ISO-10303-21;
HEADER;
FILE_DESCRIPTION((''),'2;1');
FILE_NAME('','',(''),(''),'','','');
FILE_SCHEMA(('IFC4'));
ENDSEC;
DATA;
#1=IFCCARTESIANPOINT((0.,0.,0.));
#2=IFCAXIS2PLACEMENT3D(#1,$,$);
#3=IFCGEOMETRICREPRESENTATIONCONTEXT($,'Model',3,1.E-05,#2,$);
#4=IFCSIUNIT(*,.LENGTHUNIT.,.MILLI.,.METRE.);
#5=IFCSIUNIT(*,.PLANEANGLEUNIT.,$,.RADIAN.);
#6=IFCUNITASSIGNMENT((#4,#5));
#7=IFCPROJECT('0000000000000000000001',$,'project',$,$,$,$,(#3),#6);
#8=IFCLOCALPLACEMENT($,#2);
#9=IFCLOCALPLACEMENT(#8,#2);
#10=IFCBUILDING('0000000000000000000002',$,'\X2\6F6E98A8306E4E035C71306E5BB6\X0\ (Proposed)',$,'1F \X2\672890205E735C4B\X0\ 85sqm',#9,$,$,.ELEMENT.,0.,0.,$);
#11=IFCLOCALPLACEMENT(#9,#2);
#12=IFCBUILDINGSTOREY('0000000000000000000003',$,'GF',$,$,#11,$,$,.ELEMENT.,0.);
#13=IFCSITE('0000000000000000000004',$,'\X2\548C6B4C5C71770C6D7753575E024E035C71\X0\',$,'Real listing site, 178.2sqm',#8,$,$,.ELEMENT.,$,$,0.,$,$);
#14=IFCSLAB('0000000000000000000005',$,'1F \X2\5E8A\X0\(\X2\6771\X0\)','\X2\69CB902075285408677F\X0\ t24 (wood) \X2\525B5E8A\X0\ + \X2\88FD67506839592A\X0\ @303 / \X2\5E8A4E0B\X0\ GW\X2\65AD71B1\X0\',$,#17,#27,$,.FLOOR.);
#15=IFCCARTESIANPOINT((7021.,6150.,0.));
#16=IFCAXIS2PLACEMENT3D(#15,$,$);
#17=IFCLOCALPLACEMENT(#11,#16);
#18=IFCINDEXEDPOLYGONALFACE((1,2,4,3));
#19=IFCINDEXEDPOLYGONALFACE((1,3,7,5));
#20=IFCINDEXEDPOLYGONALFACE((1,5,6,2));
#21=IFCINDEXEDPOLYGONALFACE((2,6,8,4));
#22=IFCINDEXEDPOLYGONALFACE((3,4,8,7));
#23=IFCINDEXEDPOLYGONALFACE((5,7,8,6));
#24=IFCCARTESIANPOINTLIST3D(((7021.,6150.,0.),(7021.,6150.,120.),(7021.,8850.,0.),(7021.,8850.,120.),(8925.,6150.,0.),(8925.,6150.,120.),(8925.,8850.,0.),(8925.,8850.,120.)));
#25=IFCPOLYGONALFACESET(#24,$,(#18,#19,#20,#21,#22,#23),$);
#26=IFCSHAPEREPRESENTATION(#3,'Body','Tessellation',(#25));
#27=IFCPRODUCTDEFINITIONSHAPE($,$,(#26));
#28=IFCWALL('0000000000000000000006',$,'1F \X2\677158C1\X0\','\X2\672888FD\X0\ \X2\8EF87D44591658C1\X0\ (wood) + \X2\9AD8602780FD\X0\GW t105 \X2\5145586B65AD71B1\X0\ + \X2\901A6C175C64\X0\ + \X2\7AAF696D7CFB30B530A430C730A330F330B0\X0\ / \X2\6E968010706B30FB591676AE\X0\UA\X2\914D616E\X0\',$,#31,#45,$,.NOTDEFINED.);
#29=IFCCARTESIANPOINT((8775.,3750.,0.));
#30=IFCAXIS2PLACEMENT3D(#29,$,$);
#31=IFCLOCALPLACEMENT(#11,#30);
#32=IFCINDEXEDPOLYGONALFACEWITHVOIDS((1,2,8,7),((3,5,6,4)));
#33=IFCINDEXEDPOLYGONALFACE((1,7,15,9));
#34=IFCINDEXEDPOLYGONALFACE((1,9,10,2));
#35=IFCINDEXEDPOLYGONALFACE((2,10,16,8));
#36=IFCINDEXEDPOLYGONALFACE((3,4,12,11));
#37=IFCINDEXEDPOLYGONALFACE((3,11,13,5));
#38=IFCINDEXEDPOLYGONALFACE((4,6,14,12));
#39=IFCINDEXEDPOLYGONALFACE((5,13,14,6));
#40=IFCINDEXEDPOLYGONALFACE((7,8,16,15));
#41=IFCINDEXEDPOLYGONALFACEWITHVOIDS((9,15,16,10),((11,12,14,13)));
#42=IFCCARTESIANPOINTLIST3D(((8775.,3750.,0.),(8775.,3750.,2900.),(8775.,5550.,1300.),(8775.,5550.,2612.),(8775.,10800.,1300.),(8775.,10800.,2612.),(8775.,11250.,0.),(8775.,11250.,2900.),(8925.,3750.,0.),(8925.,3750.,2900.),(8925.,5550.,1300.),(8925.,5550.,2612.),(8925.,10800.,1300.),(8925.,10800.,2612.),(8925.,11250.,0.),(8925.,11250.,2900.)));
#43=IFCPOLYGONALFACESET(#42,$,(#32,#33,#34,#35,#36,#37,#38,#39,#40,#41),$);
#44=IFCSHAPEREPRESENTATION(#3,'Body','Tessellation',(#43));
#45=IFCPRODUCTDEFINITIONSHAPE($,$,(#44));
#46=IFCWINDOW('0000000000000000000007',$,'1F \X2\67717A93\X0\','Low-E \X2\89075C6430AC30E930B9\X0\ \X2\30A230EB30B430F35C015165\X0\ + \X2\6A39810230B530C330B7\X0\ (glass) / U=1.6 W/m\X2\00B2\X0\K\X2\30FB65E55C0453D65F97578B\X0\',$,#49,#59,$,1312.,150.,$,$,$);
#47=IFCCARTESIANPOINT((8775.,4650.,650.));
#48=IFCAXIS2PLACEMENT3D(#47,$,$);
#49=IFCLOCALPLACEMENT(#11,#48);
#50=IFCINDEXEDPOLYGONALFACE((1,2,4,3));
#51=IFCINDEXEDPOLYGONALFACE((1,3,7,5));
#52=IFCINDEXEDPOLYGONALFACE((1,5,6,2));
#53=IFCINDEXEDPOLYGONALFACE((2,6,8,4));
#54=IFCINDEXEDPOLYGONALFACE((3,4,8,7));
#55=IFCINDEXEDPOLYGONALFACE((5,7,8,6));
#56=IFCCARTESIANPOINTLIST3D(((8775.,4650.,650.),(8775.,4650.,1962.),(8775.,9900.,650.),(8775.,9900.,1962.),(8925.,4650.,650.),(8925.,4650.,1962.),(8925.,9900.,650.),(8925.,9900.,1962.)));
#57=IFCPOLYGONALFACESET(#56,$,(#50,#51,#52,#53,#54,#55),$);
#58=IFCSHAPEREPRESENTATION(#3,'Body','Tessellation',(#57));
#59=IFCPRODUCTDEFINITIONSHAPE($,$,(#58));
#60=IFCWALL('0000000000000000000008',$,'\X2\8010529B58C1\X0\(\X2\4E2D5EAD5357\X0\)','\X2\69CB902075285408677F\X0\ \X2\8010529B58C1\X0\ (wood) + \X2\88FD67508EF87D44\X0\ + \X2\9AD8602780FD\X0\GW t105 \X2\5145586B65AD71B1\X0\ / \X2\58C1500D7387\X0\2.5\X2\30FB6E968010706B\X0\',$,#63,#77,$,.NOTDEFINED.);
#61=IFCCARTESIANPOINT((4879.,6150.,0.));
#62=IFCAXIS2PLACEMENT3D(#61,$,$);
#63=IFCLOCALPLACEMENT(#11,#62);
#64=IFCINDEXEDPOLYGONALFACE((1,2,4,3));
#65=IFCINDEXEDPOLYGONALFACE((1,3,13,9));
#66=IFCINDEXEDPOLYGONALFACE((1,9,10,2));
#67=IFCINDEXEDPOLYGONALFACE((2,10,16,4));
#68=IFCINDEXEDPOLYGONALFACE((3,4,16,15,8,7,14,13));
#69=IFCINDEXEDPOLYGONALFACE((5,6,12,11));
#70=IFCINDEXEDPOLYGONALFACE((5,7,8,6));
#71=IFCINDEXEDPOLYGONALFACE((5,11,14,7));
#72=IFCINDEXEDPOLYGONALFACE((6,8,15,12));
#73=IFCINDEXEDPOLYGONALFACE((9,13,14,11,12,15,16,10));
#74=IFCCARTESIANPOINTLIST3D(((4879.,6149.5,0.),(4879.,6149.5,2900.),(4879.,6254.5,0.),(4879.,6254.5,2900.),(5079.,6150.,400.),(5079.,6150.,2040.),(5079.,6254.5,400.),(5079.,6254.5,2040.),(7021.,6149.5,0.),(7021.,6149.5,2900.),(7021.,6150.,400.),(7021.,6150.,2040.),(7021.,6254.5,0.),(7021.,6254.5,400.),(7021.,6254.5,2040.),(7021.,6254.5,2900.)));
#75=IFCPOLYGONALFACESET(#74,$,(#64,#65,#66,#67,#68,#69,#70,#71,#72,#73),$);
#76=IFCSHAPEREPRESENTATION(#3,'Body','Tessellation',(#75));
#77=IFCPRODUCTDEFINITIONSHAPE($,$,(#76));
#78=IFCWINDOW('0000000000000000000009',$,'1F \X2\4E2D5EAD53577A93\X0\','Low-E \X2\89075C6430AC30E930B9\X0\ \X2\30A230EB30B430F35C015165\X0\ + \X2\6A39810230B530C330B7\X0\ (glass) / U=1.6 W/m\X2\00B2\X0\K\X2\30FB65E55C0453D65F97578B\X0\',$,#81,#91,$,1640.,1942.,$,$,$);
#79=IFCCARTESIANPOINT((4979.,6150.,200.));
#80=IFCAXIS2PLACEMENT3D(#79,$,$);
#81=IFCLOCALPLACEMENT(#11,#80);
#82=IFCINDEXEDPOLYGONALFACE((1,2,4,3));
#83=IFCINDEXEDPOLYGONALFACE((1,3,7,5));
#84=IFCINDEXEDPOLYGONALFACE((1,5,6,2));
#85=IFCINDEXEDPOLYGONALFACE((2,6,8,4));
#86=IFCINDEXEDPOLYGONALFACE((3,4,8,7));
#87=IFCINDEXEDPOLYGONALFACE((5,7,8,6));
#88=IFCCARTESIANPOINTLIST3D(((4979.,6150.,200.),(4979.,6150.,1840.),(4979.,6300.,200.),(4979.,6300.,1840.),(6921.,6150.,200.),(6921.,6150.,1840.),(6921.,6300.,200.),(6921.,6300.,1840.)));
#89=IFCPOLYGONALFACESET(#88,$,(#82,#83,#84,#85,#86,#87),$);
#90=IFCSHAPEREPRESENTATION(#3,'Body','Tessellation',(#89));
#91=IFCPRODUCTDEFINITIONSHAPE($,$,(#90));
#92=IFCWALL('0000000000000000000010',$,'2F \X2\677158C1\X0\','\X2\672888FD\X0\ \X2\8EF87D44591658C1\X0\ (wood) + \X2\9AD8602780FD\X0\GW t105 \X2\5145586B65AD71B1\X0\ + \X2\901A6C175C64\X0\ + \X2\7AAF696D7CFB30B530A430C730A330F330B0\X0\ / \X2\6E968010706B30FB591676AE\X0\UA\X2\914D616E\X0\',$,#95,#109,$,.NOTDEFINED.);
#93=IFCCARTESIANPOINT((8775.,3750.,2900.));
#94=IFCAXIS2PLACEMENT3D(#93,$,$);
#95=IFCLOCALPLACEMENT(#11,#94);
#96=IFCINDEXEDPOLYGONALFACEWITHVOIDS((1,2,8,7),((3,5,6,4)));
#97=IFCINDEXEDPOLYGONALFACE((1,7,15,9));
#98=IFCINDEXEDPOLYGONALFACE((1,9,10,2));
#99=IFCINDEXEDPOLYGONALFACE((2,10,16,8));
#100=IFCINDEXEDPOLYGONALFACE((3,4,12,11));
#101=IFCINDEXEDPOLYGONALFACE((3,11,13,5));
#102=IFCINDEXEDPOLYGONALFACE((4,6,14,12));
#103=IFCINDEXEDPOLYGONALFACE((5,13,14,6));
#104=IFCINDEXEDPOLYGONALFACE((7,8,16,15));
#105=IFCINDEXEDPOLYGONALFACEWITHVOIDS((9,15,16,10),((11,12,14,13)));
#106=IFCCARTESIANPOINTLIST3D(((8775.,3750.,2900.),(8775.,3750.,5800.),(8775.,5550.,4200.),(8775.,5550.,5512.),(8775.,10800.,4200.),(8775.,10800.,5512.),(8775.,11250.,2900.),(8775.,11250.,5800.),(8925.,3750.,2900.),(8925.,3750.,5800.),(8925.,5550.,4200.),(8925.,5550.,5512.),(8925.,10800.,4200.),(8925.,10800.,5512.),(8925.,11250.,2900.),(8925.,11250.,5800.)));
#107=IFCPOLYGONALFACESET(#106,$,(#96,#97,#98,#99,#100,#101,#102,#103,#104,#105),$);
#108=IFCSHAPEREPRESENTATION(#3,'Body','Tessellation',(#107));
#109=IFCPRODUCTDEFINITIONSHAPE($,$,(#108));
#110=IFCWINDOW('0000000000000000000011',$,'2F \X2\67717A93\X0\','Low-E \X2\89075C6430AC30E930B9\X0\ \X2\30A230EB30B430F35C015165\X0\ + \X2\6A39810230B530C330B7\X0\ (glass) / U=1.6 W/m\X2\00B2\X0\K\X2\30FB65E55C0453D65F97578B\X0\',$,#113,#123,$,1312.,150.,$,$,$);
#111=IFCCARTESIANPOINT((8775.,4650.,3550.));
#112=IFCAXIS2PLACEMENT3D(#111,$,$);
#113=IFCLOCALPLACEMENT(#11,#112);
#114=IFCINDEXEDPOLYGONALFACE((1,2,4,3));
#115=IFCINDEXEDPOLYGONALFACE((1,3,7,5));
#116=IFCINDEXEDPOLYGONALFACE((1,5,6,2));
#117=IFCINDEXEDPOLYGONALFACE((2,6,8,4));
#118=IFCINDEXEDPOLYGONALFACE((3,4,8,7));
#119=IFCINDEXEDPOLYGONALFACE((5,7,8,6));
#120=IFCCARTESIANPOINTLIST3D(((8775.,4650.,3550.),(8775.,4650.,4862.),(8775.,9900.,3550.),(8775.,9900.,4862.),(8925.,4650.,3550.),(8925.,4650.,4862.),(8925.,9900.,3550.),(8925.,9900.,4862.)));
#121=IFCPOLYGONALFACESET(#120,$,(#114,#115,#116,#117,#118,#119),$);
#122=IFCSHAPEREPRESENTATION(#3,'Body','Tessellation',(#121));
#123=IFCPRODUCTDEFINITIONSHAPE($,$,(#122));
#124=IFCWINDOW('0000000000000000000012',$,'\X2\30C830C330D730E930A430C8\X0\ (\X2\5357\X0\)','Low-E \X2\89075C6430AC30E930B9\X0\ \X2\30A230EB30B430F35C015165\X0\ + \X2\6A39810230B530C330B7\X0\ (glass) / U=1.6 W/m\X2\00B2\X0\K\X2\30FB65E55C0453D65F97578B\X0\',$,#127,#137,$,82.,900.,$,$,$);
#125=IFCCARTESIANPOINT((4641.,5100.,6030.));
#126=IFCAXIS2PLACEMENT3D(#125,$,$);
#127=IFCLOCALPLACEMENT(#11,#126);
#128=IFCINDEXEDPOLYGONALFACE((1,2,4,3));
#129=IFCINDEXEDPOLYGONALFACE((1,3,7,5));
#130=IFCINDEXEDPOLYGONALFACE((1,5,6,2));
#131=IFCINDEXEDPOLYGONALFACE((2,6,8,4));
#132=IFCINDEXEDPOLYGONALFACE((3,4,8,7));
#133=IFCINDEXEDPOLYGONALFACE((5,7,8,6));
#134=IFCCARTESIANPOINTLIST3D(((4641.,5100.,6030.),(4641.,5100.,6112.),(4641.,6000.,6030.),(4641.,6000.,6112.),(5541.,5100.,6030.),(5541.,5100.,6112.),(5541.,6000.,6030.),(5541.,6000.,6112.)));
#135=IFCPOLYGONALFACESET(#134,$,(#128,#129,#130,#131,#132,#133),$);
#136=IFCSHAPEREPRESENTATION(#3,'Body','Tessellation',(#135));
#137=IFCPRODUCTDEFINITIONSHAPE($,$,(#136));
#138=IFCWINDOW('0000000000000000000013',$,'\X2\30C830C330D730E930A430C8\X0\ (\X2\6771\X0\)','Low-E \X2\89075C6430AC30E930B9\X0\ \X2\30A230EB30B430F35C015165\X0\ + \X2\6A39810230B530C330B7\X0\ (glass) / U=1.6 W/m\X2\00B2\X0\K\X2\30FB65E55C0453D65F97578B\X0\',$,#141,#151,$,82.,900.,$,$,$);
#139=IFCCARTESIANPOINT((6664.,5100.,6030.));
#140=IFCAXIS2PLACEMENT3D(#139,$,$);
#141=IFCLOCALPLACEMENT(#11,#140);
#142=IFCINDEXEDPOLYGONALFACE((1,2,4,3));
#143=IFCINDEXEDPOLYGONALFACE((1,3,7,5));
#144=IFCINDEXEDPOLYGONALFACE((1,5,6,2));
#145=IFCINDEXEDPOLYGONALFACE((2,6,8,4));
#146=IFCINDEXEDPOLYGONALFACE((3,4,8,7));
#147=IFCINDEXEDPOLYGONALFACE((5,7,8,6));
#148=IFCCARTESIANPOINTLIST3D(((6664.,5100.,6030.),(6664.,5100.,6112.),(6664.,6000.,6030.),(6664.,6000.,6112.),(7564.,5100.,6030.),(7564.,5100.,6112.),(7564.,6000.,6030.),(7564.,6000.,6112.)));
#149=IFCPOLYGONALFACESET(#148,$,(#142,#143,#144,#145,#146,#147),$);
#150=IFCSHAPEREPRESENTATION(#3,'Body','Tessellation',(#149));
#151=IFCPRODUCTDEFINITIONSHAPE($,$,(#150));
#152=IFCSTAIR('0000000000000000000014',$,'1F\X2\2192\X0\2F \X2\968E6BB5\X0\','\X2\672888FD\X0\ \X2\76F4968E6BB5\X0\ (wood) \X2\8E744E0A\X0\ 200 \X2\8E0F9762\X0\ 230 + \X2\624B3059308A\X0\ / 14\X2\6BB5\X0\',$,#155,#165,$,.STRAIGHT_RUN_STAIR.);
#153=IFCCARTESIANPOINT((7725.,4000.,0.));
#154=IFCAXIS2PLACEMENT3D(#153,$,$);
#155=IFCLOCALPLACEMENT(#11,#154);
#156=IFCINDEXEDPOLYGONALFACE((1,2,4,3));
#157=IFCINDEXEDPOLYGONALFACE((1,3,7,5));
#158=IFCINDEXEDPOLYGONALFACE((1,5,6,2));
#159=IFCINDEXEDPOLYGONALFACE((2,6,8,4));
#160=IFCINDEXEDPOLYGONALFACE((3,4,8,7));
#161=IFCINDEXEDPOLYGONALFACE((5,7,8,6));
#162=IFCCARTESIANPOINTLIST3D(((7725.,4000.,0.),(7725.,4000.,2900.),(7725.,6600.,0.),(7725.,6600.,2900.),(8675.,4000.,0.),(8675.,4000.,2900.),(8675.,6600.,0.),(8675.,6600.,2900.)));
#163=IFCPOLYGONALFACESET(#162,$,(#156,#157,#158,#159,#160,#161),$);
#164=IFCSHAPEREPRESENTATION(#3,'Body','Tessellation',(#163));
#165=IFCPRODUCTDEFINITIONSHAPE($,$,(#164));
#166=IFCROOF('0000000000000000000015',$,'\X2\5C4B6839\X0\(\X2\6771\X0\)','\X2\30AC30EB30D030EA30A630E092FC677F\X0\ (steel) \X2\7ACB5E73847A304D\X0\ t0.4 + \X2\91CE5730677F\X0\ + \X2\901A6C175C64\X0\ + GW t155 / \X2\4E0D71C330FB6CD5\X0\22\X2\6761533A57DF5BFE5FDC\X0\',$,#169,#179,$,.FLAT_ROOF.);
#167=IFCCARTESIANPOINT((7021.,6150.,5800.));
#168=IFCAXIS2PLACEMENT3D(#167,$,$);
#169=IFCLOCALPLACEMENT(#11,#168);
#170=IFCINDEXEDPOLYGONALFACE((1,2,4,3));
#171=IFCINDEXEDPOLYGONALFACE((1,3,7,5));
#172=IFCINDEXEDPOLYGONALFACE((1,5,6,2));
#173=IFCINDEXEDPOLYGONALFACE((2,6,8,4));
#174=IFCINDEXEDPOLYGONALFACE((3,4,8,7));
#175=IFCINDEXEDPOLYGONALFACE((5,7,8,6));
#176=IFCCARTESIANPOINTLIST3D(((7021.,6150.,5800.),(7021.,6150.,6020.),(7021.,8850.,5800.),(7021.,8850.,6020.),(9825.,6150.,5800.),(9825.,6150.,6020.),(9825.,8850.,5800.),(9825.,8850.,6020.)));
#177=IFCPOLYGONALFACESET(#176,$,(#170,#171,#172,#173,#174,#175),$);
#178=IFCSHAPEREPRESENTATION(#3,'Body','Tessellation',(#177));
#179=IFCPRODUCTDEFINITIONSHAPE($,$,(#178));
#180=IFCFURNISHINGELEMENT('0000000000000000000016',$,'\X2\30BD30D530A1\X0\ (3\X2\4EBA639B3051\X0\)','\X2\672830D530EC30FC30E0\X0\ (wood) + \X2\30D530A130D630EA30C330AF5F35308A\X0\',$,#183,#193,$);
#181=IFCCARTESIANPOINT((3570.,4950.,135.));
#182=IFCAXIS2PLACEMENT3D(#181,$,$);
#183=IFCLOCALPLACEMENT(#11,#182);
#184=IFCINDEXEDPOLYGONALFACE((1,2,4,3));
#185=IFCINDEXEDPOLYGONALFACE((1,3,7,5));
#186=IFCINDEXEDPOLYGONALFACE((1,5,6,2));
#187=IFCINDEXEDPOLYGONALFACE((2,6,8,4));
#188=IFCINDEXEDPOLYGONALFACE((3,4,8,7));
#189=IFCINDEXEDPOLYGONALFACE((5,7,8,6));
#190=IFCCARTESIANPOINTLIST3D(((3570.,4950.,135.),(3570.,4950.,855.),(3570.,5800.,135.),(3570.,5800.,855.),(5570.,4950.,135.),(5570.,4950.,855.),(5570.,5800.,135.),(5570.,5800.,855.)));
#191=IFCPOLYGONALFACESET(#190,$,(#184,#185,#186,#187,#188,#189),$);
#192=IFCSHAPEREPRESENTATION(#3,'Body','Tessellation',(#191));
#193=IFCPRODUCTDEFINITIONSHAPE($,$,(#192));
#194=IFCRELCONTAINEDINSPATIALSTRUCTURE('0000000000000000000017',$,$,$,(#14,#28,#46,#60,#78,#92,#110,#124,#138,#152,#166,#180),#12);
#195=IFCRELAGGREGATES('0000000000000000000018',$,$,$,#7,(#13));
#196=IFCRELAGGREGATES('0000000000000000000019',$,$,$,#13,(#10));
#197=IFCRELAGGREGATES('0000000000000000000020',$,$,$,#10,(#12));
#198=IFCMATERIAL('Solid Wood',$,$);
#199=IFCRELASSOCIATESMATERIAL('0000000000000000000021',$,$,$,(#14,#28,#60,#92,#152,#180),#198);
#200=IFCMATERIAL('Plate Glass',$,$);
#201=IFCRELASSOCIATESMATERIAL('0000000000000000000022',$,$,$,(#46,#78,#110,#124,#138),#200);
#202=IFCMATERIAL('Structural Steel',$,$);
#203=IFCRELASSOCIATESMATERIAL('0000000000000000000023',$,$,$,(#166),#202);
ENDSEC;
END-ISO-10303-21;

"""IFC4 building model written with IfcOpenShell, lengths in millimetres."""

from ifc_helpers import new_model, si_unit, frame, frame_2d, origin, place, context, project, spatial, rectangle, extrude, material, element, fill, save


model = new_model("IFC4")

# Units and contexts
model_context = context("Model", 3, precision=1e-05, world=origin())
ifc_project = project(units=[si_unit("LENGTHUNIT", "METRE", prefix="MILLI"), si_unit("PLANEANGLEUNIT", "RADIAN")], contexts=[model_context])

# Site, building, storey
site_placement = place(None, origin())
site = spatial("IfcSite", under=ifc_project, at=site_placement, Name="和歌山県海南市七山", ObjectType="Real listing site, 178.2sqm", CompositionType="ELEMENT", RefElevation=0.0)
building_placement = place(site_placement, origin())
building = spatial("IfcBuilding", under=site, at=building_placement, Name="潮風の七山の家 (Proposed)", ObjectType="1F 木造平屋 85sqm", CompositionType="ELEMENT", ElevationOfRefHeight=0.0, ElevationOfTerrain=0.0)
storey_placement = place(building_placement, origin())
storey = spatial("IfcBuildingStorey", under=building, at=storey_placement, Name="GF", CompositionType="ELEMENT", Elevation=0.0)

# Slab
ifc_material_1 = material(Name="Solid Wood")
slab_placement = place(storey_placement, frame((7021.0, 6150.0, 0.0)))
element("IfcSlab", 1, at=slab_placement, inside=storey, material=ifc_material_1, Name="1F 床(東)", Description="構造用合板 t24 (wood) 剛床 + 製材根太 @303 / 床下 GW断熱", PredefinedType="FLOOR", context=model_context, shape_type="SweptSolid", body=[
    extrude(rectangle(XDim=1904.0, YDim=2700.0, at=frame_2d((952.0, 1350.0))), frame((7021.0, 6150.0, 0.0)), (0.0, 0.0, 1.0), 120.0),
])

# Walls, openings, windows
wall_1_placement = place(storey_placement, frame((8775.0, 3750.0, 0.0)))
wall_1 = element("IfcWall", 2, at=wall_1_placement, inside=storey, material=ifc_material_1, Name="1F 東壁", Description="木製 軸組外壁 (wood) + 高性能GW t105 充填断熱 + 通気層 + 窯業系サイディング / 準耐火・外皮UA配慮", PredefinedType="NOTDEFINED", context=model_context, shape_type="SweptSolid", body=[
    extrude(rectangle(XDim=150.0, YDim=7500.0, at=frame_2d((75.0, 3750.0))), frame((8775.0, 3750.0, 0.0)), (0.0, 0.0, 1.0), 2900.0),
])
opening_1_placement = place(storey_placement, frame((8775.0, 4650.0, 650.0)))
opening_1 = element("IfcOpeningElement", 3, at=opening_1_placement, cuts=wall_1, PredefinedType="NOTDEFINED", context=model_context, shape_type="SweptSolid", body=[
    extrude(rectangle(XDim=150.0, YDim=5250.0, at=frame_2d((75.0, 2625.0))), frame((8775.0, 4650.0, 650.0)), (0.0, 0.0, 1.0), 1312.0),
])
ifc_material_2 = material(Name="Plate Glass")
window_1_placement = place(storey_placement, frame((8775.0, 4650.0, 650.0)))
window_1 = element("IfcWindow", 4, at=window_1_placement, inside=storey, material=ifc_material_2, Name="1F 東窓", Description="Low-E 複層ガラス アルゴン封入 + 樹脂サッシ (glass) / U=1.6 W/m²K・日射取得型", OverallHeight=1312.0, OverallWidth=150.0, context=model_context, shape_type="SweptSolid", body=[
    extrude(rectangle(XDim=150.0, YDim=5250.0, at=frame_2d((75.0, 2625.0))), frame((8775.0, 4650.0, 650.0)), (0.0, 0.0, 1.0), 1312.0),
])
fill(opening_1, window_1)
wall_2_placement = place(storey_placement, frame((4879.0, 6150.0, 0.0)))
wall_2 = element("IfcWall", 5, at=wall_2_placement, inside=storey, material=ifc_material_1, Name="耐力壁(中庭南)", Description="構造用合板 耐力壁 (wood) + 製材軸組 + 高性能GW t105 充填断熱 / 壁倍率2.5・準耐火", PredefinedType="NOTDEFINED", context=model_context, shape_type="SweptSolid", body=[
    extrude(rectangle(XDim=2142.0, YDim=105.0, at=frame_2d((1071.0, 52.0))), frame((4879.0, 6150.0, 0.0)), (0.0, 0.0, 1.0), 2900.0),
])
opening_2_placement = place(storey_placement, frame((4979.0, 6150.0, 200.0)))
opening_2 = element("IfcOpeningElement", 6, at=opening_2_placement, cuts=wall_2, PredefinedType="NOTDEFINED", context=model_context, shape_type="SweptSolid", body=[
    extrude(rectangle(XDim=1942.0, YDim=150.0, at=frame_2d((971.0, 75.0))), frame((4979.0, 6150.0, 200.0)), (0.0, 0.0, 1.0), 1640.0),
])
window_2_placement = place(storey_placement, frame((4979.0, 6150.0, 200.0)))
window_2 = element("IfcWindow", 7, at=window_2_placement, inside=storey, material=ifc_material_2, Name="1F 中庭南窓", Description="Low-E 複層ガラス アルゴン封入 + 樹脂サッシ (glass) / U=1.6 W/m²K・日射取得型", OverallHeight=1640.0, OverallWidth=1942.0, context=model_context, shape_type="SweptSolid", body=[
    extrude(rectangle(XDim=1942.0, YDim=150.0, at=frame_2d((971.0, 75.0))), frame((4979.0, 6150.0, 200.0)), (0.0, 0.0, 1.0), 1640.0),
])
fill(opening_2, window_2)

# Wall, opening, window
wall_3_placement = place(storey_placement, frame((8775.0, 3750.0, 2900.0)))
wall_3 = element("IfcWall", 8, at=wall_3_placement, inside=storey, material=ifc_material_1, Name="2F 東壁", Description="木製 軸組外壁 (wood) + 高性能GW t105 充填断熱 + 通気層 + 窯業系サイディング / 準耐火・外皮UA配慮", PredefinedType="NOTDEFINED", context=model_context, shape_type="SweptSolid", body=[
    extrude(rectangle(XDim=150.0, YDim=7500.0, at=frame_2d((75.0, 3750.0))), frame((8775.0, 3750.0, 2900.0)), (0.0, 0.0, 1.0), 2900.0),
])
opening_3_placement = place(storey_placement, frame((8775.0, 4650.0, 3550.0)))
opening_3 = element("IfcOpeningElement", 9, at=opening_3_placement, cuts=wall_3, PredefinedType="NOTDEFINED", context=model_context, shape_type="SweptSolid", body=[
    extrude(rectangle(XDim=150.0, YDim=5250.0, at=frame_2d((75.0, 2625.0))), frame((8775.0, 4650.0, 3550.0)), (0.0, 0.0, 1.0), 1312.0),
])
window_3_placement = place(storey_placement, frame((8775.0, 4650.0, 3550.0)))
window_3 = element("IfcWindow", 10, at=window_3_placement, inside=storey, material=ifc_material_2, Name="2F 東窓", Description="Low-E 複層ガラス アルゴン封入 + 樹脂サッシ (glass) / U=1.6 W/m²K・日射取得型", OverallHeight=1312.0, OverallWidth=150.0, context=model_context, shape_type="SweptSolid", body=[
    extrude(rectangle(XDim=150.0, YDim=5250.0, at=frame_2d((75.0, 2625.0))), frame((8775.0, 4650.0, 3550.0)), (0.0, 0.0, 1.0), 1312.0),
])
fill(opening_3, window_3)

# Windows
window_4_placement = place(storey_placement, frame((4641.0, 5100.0, 6030.0)))
element("IfcWindow", 11, at=window_4_placement, inside=storey, material=ifc_material_2, Name="トップライト (南)", Description="Low-E 複層ガラス アルゴン封入 + 樹脂サッシ (glass) / U=1.6 W/m²K・日射取得型", OverallHeight=82.0, OverallWidth=900.0, context=model_context, shape_type="SweptSolid", body=[
    extrude(rectangle(XDim=900.0, YDim=900.0, at=frame_2d((450.0, 450.0))), frame((4641.0, 5100.0, 6030.0)), (0.0, 0.0, 1.0), 82.0),
])
window_5_placement = place(storey_placement, frame((6664.0, 5100.0, 6030.0)))
element("IfcWindow", 12, at=window_5_placement, inside=storey, material=ifc_material_2, Name="トップライト (東)", Description="Low-E 複層ガラス アルゴン封入 + 樹脂サッシ (glass) / U=1.6 W/m²K・日射取得型", OverallHeight=82.0, OverallWidth=900.0, context=model_context, shape_type="SweptSolid", body=[
    extrude(rectangle(XDim=900.0, YDim=900.0, at=frame_2d((450.0, 450.0))), frame((6664.0, 5100.0, 6030.0)), (0.0, 0.0, 1.0), 82.0),
])

# Stair
stair_placement = place(storey_placement, frame((7725.0, 4000.0, 0.0)))
element("IfcStair", 13, at=stair_placement, inside=storey, material=ifc_material_1, Name="1F→2F 階段", Description="木製 直階段 (wood) 蹴上 200 踏面 230 + 手すり / 14段", PredefinedType="STRAIGHT_RUN_STAIR", context=model_context, shape_type="SweptSolid", body=[
    extrude(rectangle(XDim=950.0, YDim=2600.0, at=frame_2d((475.0, 1300.0))), frame((7725.0, 4000.0, 0.0)), (0.0, 0.0, 1.0), 2900.0),
])

# Roof
ifc_material_3 = material(Name="Structural Steel")
roof_placement = place(storey_placement, frame((7021.0, 6150.0, 5800.0)))
element("IfcRoof", 14, at=roof_placement, inside=storey, material=ifc_material_3, Name="屋根(東)", Description="ガルバリウム鋼板 (steel) 立平葺き t0.4 + 野地板 + 通気層 + GW t155 / 不燃・法22条区域対応", PredefinedType="FLAT_ROOF", context=model_context, shape_type="SweptSolid", body=[
    extrude(rectangle(XDim=2804.0, YDim=2700.0, at=frame_2d((1402.0, 1350.0))), frame((7021.0, 6150.0, 5800.0)), (0.0, 0.0, 1.0), 220.0),
])

# Furnishing element
furnishing_1_placement = place(storey_placement, frame((3570.0, 4950.0, 135.0)))
element("IfcFurnishingElement", 15, at=furnishing_1_placement, inside=storey, material=ifc_material_1, Name="ソファ (3人掛け)", Description="木フレーム (wood) + ファブリック張り", context=model_context, shape_type="SweptSolid", body=[
    extrude(rectangle(XDim=2000.0, YDim=850.0, at=frame_2d((1000.0, 425.0))), frame((3570.0, 4950.0, 135.0)), (0.0, 0.0, 1.0), 720.0),
])

save(model, "model.ifc")
